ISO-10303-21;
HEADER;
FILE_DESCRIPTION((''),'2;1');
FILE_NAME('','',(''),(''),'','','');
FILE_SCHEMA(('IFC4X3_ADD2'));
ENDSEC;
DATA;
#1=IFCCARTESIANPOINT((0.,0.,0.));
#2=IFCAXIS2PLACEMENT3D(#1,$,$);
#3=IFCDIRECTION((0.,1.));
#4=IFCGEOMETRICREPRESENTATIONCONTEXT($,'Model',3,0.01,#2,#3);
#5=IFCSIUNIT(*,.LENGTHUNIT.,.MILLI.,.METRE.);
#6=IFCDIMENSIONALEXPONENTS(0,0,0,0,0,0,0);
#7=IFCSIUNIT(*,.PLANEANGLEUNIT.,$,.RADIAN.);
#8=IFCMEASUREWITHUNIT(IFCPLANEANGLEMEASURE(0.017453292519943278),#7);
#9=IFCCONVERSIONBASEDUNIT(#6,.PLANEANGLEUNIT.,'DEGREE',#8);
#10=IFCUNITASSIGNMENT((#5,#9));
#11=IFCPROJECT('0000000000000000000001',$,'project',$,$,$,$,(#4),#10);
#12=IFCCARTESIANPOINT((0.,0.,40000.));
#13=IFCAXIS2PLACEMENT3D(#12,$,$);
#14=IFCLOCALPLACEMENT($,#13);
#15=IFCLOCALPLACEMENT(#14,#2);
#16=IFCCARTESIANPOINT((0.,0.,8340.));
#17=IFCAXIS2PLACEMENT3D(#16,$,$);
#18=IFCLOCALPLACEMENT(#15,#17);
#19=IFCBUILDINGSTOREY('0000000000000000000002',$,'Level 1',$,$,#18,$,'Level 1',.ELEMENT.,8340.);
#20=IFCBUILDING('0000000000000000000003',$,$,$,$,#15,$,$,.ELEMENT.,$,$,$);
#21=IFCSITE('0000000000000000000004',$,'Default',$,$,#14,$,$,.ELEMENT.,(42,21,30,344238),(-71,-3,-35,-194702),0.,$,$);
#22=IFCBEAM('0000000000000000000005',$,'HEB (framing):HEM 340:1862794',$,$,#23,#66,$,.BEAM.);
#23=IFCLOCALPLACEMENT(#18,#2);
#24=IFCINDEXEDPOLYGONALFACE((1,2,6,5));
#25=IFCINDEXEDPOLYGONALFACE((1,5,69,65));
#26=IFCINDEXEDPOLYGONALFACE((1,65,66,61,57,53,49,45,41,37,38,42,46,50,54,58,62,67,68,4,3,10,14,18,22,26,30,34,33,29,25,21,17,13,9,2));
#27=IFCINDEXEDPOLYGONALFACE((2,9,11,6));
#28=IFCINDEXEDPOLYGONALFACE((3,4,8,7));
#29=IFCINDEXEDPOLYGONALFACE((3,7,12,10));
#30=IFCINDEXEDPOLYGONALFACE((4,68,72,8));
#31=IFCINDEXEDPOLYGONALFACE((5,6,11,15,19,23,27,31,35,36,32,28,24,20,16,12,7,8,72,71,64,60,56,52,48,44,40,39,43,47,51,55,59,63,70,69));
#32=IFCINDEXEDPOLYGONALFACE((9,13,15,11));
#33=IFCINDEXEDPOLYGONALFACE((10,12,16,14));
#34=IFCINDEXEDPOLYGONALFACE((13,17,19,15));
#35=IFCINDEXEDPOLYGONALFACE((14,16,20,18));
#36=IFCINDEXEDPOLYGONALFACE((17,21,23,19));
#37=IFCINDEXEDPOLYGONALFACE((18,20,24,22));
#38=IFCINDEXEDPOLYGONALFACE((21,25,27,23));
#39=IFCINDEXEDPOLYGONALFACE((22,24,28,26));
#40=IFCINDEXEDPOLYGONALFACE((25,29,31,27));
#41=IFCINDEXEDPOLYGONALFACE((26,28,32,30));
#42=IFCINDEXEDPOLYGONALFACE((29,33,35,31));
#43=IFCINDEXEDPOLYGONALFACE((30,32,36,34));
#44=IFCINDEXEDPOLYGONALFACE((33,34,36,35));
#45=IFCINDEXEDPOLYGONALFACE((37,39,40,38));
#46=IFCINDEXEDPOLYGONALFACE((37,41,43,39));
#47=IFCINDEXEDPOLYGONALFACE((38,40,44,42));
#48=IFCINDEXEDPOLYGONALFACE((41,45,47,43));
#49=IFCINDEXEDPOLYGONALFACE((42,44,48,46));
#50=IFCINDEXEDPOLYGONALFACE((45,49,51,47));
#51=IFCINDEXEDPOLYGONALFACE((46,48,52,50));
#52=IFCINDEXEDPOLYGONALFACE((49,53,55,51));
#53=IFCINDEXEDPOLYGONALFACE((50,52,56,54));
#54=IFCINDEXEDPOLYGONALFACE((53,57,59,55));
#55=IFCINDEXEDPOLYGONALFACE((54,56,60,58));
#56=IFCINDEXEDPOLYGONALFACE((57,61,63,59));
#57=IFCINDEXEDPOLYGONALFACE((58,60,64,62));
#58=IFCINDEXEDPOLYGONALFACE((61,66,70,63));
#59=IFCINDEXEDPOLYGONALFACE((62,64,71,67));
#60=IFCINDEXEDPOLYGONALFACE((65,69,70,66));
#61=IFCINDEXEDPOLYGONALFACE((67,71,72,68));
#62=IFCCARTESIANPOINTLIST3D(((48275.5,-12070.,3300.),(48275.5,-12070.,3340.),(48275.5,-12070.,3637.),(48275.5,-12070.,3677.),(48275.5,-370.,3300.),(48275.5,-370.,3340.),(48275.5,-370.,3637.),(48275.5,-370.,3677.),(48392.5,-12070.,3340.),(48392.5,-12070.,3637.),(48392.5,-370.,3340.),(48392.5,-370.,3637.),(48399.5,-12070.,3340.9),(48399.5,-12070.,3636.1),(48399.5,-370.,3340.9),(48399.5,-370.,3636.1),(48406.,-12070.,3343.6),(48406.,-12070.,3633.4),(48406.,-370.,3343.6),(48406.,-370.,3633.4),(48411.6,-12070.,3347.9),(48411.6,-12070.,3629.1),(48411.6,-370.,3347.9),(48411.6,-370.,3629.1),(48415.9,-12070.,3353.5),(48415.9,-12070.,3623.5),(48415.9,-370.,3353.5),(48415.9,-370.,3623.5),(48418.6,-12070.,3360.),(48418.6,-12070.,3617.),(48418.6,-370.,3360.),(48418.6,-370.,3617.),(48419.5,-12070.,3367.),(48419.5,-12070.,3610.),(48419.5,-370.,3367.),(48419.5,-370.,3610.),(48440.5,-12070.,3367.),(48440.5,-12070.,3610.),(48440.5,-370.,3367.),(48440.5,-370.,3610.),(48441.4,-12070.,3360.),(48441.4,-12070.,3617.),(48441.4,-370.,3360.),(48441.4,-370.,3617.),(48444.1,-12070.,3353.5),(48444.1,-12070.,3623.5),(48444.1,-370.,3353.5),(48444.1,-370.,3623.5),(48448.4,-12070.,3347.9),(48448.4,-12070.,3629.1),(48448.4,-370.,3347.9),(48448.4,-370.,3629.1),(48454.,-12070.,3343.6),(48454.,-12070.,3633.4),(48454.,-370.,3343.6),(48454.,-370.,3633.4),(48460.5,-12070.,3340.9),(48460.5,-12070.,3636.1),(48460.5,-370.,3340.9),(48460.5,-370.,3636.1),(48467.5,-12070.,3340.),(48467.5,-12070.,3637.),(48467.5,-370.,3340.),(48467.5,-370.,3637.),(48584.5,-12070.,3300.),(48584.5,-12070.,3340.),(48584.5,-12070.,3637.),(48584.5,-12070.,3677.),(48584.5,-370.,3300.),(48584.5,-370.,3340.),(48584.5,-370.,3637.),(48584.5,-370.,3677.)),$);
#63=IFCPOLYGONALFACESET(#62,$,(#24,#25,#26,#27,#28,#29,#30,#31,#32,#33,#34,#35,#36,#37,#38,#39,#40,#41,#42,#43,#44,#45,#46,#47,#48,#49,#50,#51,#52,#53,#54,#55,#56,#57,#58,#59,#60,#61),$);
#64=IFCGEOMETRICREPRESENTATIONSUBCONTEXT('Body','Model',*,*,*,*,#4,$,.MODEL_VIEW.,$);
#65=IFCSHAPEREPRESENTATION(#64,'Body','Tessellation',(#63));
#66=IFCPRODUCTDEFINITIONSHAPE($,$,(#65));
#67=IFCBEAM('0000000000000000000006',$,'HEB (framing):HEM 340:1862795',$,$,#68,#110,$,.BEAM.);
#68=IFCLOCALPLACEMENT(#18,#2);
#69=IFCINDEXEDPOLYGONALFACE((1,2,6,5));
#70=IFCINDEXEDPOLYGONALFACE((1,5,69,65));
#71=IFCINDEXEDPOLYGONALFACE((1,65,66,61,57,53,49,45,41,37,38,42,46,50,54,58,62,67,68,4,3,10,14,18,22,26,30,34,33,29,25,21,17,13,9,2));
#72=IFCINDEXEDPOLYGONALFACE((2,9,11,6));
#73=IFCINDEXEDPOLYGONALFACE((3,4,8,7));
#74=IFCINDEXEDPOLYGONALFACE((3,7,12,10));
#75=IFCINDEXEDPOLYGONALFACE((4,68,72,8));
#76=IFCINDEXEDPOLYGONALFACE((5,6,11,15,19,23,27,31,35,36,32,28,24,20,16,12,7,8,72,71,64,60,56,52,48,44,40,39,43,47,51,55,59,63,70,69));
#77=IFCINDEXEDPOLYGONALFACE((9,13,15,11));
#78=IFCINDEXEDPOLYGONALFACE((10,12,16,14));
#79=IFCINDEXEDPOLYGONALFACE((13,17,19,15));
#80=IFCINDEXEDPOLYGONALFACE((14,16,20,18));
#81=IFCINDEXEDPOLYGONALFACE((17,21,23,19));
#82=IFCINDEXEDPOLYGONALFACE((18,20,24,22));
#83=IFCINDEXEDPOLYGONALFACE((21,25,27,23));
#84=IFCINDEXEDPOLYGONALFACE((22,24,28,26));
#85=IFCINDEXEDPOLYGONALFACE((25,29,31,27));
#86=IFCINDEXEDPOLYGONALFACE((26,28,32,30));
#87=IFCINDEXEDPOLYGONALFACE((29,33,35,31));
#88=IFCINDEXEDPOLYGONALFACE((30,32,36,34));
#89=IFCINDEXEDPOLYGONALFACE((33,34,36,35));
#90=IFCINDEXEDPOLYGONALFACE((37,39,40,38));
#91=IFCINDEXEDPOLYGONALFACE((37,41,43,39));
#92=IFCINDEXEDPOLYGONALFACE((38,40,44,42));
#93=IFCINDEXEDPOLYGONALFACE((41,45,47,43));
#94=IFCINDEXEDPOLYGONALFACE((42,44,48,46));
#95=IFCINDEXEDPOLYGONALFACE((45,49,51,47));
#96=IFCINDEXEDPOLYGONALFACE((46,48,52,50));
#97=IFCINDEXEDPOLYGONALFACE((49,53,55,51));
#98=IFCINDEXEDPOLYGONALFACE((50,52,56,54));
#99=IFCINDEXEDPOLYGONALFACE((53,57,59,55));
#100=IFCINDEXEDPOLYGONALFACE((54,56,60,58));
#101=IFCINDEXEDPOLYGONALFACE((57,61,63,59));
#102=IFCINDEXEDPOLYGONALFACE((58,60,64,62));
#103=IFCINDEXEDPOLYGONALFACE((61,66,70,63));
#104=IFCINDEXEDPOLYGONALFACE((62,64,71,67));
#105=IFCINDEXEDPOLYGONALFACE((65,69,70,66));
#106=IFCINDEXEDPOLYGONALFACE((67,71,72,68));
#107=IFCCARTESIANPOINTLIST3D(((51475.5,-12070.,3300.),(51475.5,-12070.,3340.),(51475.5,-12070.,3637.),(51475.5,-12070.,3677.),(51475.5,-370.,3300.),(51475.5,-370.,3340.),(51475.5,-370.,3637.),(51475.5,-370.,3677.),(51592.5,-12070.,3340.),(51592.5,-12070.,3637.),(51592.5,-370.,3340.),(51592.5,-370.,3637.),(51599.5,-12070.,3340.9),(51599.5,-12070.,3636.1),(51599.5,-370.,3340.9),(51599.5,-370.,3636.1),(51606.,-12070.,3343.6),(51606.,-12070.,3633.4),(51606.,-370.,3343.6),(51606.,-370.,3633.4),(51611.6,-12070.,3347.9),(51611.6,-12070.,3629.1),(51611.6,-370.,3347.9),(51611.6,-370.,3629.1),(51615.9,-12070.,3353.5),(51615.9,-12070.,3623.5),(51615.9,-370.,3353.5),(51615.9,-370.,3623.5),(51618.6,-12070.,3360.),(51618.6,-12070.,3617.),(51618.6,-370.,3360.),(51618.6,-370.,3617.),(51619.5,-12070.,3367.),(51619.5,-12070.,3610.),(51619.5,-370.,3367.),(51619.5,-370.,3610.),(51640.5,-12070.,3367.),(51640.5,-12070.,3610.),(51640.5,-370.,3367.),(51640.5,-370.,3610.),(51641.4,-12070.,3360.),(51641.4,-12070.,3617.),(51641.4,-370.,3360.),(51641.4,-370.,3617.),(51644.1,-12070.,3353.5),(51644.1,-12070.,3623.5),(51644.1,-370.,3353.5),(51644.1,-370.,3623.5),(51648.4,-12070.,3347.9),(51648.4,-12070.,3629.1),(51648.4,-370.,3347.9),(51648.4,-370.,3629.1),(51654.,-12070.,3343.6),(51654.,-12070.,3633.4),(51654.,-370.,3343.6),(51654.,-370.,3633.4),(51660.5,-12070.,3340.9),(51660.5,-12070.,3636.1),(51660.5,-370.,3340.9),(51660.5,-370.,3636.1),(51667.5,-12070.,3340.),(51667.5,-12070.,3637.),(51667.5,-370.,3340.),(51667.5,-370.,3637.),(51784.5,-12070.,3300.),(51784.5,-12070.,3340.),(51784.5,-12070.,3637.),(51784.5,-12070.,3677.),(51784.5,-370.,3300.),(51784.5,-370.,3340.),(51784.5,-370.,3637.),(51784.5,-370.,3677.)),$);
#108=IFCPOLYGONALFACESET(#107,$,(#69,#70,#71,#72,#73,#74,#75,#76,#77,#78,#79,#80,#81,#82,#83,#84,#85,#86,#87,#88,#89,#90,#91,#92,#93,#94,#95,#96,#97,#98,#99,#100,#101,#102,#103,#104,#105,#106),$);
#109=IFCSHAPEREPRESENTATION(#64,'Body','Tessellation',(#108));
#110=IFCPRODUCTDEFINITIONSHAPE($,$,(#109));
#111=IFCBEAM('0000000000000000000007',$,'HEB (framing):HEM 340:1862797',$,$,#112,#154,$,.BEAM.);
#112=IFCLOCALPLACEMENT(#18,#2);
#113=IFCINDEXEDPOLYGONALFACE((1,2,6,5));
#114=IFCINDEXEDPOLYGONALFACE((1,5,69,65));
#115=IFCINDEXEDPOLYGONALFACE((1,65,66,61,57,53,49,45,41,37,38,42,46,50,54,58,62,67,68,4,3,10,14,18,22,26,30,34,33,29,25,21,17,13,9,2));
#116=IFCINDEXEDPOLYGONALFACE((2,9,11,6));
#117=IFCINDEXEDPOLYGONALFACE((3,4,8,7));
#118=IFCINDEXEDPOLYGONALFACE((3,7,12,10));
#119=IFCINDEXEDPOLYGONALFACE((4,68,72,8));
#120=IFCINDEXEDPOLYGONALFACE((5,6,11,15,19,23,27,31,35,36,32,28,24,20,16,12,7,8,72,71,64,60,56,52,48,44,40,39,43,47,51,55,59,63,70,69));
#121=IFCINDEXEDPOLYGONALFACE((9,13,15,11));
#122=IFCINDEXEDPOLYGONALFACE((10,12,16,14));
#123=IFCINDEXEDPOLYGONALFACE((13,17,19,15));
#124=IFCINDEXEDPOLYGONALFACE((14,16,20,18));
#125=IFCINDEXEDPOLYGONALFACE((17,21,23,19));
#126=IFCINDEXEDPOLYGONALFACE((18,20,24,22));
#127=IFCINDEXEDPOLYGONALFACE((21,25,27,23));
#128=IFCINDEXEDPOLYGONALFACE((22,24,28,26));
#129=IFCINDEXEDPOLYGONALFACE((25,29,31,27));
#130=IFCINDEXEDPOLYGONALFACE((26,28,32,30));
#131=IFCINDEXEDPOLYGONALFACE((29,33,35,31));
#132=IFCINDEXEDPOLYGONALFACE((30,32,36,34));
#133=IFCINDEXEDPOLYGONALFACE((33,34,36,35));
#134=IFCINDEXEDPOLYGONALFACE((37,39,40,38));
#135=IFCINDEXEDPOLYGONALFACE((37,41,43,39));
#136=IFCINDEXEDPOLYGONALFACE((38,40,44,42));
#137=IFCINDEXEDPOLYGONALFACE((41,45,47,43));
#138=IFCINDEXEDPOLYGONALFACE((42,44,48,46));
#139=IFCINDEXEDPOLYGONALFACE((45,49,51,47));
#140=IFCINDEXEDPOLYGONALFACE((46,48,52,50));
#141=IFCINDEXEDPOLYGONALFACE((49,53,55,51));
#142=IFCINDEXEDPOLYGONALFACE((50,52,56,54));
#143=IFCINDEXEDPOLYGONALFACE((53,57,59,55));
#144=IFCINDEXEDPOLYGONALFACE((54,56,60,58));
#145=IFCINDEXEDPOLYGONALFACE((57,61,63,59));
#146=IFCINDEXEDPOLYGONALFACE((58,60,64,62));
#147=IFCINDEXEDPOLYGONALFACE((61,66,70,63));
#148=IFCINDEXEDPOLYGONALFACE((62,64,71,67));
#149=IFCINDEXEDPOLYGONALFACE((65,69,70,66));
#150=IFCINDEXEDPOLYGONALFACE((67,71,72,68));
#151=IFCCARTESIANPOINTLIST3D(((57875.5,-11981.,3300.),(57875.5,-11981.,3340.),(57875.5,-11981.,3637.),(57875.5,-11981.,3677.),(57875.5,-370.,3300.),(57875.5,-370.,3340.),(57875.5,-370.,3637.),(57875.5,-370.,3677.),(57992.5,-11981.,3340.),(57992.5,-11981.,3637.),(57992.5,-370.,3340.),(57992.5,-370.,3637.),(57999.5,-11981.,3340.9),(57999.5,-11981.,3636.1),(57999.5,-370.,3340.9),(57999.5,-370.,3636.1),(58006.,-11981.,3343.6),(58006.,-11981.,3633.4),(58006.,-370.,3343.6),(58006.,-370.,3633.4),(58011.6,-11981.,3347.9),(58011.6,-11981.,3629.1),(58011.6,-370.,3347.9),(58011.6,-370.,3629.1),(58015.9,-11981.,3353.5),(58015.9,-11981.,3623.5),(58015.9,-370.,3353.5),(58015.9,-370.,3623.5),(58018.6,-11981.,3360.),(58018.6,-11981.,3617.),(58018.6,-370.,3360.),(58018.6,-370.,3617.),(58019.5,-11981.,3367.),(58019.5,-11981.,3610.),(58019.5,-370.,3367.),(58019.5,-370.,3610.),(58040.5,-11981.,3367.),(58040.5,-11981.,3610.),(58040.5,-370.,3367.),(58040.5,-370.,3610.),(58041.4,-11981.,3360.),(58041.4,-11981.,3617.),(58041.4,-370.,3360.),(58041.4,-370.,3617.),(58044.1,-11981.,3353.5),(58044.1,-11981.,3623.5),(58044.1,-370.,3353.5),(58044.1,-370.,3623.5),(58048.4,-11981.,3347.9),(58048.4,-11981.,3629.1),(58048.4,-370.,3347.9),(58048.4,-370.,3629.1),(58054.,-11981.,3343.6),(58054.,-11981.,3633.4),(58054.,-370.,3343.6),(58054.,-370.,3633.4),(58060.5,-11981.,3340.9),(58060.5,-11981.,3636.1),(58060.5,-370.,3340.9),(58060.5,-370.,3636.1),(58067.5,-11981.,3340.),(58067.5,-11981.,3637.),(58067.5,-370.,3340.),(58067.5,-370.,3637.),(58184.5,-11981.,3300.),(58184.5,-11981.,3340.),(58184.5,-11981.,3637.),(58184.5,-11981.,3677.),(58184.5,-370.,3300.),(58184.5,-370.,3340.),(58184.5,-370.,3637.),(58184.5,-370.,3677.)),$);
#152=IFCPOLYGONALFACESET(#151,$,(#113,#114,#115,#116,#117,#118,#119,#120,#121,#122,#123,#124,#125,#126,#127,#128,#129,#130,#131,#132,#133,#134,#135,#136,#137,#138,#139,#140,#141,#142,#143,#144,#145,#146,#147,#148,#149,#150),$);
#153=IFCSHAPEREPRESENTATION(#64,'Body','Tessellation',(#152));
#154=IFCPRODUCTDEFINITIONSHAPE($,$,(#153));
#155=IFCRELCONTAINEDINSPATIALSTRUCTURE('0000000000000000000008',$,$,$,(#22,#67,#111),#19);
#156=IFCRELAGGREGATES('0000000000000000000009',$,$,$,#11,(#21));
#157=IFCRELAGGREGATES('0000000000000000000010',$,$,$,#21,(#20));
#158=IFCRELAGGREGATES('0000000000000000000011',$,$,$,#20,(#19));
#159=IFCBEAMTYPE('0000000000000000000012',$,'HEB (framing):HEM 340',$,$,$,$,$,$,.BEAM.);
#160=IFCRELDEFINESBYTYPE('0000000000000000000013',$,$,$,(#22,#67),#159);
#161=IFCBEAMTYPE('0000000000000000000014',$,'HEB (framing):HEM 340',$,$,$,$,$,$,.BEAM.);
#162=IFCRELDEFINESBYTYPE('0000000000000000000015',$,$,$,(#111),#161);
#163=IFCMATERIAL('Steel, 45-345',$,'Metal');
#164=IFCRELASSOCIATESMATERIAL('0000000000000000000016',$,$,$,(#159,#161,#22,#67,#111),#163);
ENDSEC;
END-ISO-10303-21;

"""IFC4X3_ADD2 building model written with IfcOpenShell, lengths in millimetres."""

from ifc_helpers import new_model, entity, si_unit, converted_unit, direction, frame, frame_2d, origin, place, context, subcontext, project, spatial, polyline, circle_curve, parameter, trimmed, segment, composite_curve, outline, extrude, source, transform, mapped, material, material_profile, profile_set, profile_usage, type_object, type_shapes, element, save


model = new_model("IFC4X3_ADD2")

# Units and contexts
model_context = context("Model", 3, precision=0.01, world=origin(), true_north=direction((0.0, 1.0)))
body_context = subcontext(model_context, "Body", "Model", "MODEL_VIEW")
ifc_project = project(units=[si_unit("LENGTHUNIT", "METRE", prefix="MILLI"), converted_unit("PLANEANGLEUNIT", "DEGREE", entity("IfcPlaneAngleMeasure", 0.017453292519943278), si_unit("PLANEANGLEUNIT", "RADIAN"), dimensions=[0, 0, 0, 0, 0, 0, 0])], contexts=[model_context])

# Site, building, storey
site_placement = place(None, frame((0.0, 0.0, 40000.0)))
site = spatial("IfcSite", under=ifc_project, at=site_placement, Name="Default", CompositionType="ELEMENT", RefLatitude=(42, 21, 30, 344238), RefLongitude=(-71, -3, -35, -194702), RefElevation=0.0)
building_placement = place(site_placement, origin())
building = spatial("IfcBuilding", under=site, at=building_placement, CompositionType="ELEMENT")
storey_placement = place(building_placement, frame((0.0, 0.0, 8340.0)))
storey = spatial("IfcBuildingStorey", under=building, at=storey_placement, Name="Level 1", LongName="Level 1", CompositionType="ELEMENT", Elevation=8340.0)

# Shared definitions
ifc_material = material(Name="Steel, 45-345", Category="Metal")

# Beams
ifc_material_profile_1 = material_profile(ifc_material, outline(composite_curve([segment(polyline([(-154.5, -148.5), (-154.5, -188.5)]), True, "CONTINUOUS"), segment(polyline([(-154.5, -188.5), (154.5, -188.5)]), True, "CONTINUOUS"), segment(polyline([(154.5, -188.5), (154.5, -148.5)]), True, "CONTINUOUS"), segment(polyline([(154.5, -148.5), (37.5, -148.5)]), True, "CONTINUOUS"), segment(trimmed(circle_curve(frame_2d((37.5, -121.5), x_axis=(1.0, 0.0)), 27.0), [parameter(180.0)], [parameter(270.0)], True, "PARAMETER"), False, "CONTINUOUS"), segment(polyline([(10.5, -121.5), (10.5, 121.5)]), True, "CONTINUOUS"), segment(trimmed(circle_curve(frame_2d((37.5, 121.5), x_axis=(1.0, 0.0)), 27.0), [parameter(90.0)], [parameter(180.0)], True, "PARAMETER"), False, "CONTINUOUS"), segment(polyline([(37.5, 148.5), (154.5, 148.5)]), True, "CONTINUOUS"), segment(polyline([(154.5, 148.5), (154.5, 188.5)]), True, "CONTINUOUS"), segment(polyline([(154.5, 188.5), (-154.5, 188.5)]), True, "CONTINUOUS"), segment(polyline([(-154.5, 188.5), (-154.5, 148.5)]), True, "CONTINUOUS"), segment(polyline([(-154.5, 148.5), (-37.5, 148.5)]), True, "CONTINUOUS"), segment(trimmed(circle_curve(frame_2d((-37.5, 121.5), x_axis=(1.0, 0.0)), 27.0), [parameter(360.0)], [parameter(90.0)], True, "PARAMETER"), False, "CONTINUOUS"), segment(polyline([(-10.5, 121.5), (-10.5, -121.5)]), True, "CONTINUOUS"), segment(trimmed(circle_curve(frame_2d((-37.5, -121.5), x_axis=(1.0, 0.0)), 27.0), [parameter(270.0)], [parameter(0.0)], True, "PARAMETER"), False, "CONTINUOUS"), segment(polyline([(-37.5, -148.5), (-154.5, -148.5)]), True, "CONTINUOUS")], self_intersect=False)), Name="HEM 340")
ifc_profile_set_1 = profile_set([ifc_material_profile_1], Name="HEM 340")
ifc_profile_usage_1 = profile_usage(ifc_profile_set_1, cardinal=8)
beam_type_1 = type_object("IfcBeamType", Name="HEB (framing):HEM 340", PredefinedType="BEAM", material=ifc_profile_set_1)
shared_shape_1 = source(origin(), body_context, "Body", "SweptSolid", [
    extrude(outline(composite_curve([segment(polyline([(-154.5, -148.5), (-154.5, -188.5)]), True, "CONTINUOUS"), segment(polyline([(-154.5, -188.5), (154.5, -188.5)]), True, "CONTINUOUS"), segment(polyline([(154.5, -188.5), (154.5, -148.5)]), True, "CONTINUOUS"), segment(polyline([(154.5, -148.5), (37.5, -148.5)]), True, "CONTINUOUS"), segment(trimmed(circle_curve(frame_2d((37.5, -121.5), x_axis=(1.0, 0.0)), 27.0), [parameter(180.0)], [parameter(270.0)], True, "PARAMETER"), False, "CONTINUOUS"), segment(polyline([(10.5, -121.5), (10.5, 121.5)]), True, "CONTINUOUS"), segment(trimmed(circle_curve(frame_2d((37.5, 121.5), x_axis=(1.0, 0.0)), 27.0), [parameter(90.0)], [parameter(180.0)], True, "PARAMETER"), False, "CONTINUOUS"), segment(polyline([(37.5, 148.5), (154.5, 148.5)]), True, "CONTINUOUS"), segment(polyline([(154.5, 148.5), (154.5, 188.5)]), True, "CONTINUOUS"), segment(polyline([(154.5, 188.5), (-154.5, 188.5)]), True, "CONTINUOUS"), segment(polyline([(-154.5, 188.5), (-154.5, 148.5)]), True, "CONTINUOUS"), segment(polyline([(-154.5, 148.5), (-37.5, 148.5)]), True, "CONTINUOUS"), segment(trimmed(circle_curve(frame_2d((-37.5, 121.5), x_axis=(1.0, 0.0)), 27.0), [parameter(360.0)], [parameter(90.0)], True, "PARAMETER"), False, "CONTINUOUS"), segment(polyline([(-10.5, 121.5), (-10.5, -121.5)]), True, "CONTINUOUS"), segment(trimmed(circle_curve(frame_2d((-37.5, -121.5), x_axis=(1.0, 0.0)), 27.0), [parameter(270.0)], [parameter(0.0)], True, "PARAMETER"), False, "CONTINUOUS"), segment(polyline([(-37.5, -148.5), (-154.5, -148.5)]), True, "CONTINUOUS")], self_intersect=False)), frame((-5850.0, 0.0, 0.0), z_axis=(-1.0, 0.0, 0.0), x_axis=(0.0, -1.0, 0.0)), (0.0, 0.0, -1.0), 11700.0),
])
type_shapes(beam_type_1, [shared_shape_1])
for number, where, z_axis, x_axis, name in (
    (1, (48430.0, -6220.0, 3488.5), (0.0, 0.0, 1.0), (0.0, -1.0, 0.0), "HEB (framing):HEM 340:1862794"),
    (2, (51630.0, -6220.0, 3488.5), (0.0, 0.0, 1.0), (0.0, -1.0, 0.0), "HEB (framing):HEM 340:1862795"),
):
    element("IfcBeam", number, at=place(storey_placement, frame(where, z_axis=z_axis, x_axis=x_axis)), inside=storey, type_object=beam_type_1, material=ifc_profile_usage_1, Name=name, PredefinedType="BEAM", context=body_context, shape_type="MappedRepresentation", body=[
        mapped(shared_shape_1, transform((0.0, 0.0, 0.0), scale=1.0)),
    ])
beam_type_2 = type_object("IfcBeamType", Name="HEB (framing):HEM 340", PredefinedType="BEAM", material=ifc_profile_set_1)
shared_shape_2 = source(origin(), body_context, "Body", "SweptSolid", [
    extrude(outline(composite_curve([segment(polyline([(-154.5, -148.5), (-154.5, -188.5)]), True, "CONTINUOUS"), segment(polyline([(-154.5, -188.5), (154.5, -188.5)]), True, "CONTINUOUS"), segment(polyline([(154.5, -188.5), (154.5, -148.5)]), True, "CONTINUOUS"), segment(polyline([(154.5, -148.5), (37.5, -148.5)]), True, "CONTINUOUS"), segment(trimmed(circle_curve(frame_2d((37.5, -121.5), x_axis=(1.0, 0.0)), 27.0), [parameter(180.0)], [parameter(270.0)], True, "PARAMETER"), False, "CONTINUOUS"), segment(polyline([(10.5, -121.5), (10.5, 121.5)]), True, "CONTINUOUS"), segment(trimmed(circle_curve(frame_2d((37.5, 121.5), x_axis=(1.0, 0.0)), 27.0), [parameter(90.0)], [parameter(180.0)], True, "PARAMETER"), False, "CONTINUOUS"), segment(polyline([(37.5, 148.5), (154.5, 148.5)]), True, "CONTINUOUS"), segment(polyline([(154.5, 148.5), (154.5, 188.5)]), True, "CONTINUOUS"), segment(polyline([(154.5, 188.5), (-154.5, 188.5)]), True, "CONTINUOUS"), segment(polyline([(-154.5, 188.5), (-154.5, 148.5)]), True, "CONTINUOUS"), segment(polyline([(-154.5, 148.5), (-37.5, 148.5)]), True, "CONTINUOUS"), segment(trimmed(circle_curve(frame_2d((-37.5, 121.5), x_axis=(1.0, 0.0)), 27.0), [parameter(360.0)], [parameter(90.0)], True, "PARAMETER"), False, "CONTINUOUS"), segment(polyline([(-10.5, 121.5), (-10.5, -121.5)]), True, "CONTINUOUS"), segment(trimmed(circle_curve(frame_2d((-37.5, -121.5), x_axis=(1.0, 0.0)), 27.0), [parameter(270.0)], [parameter(0.0)], True, "PARAMETER"), False, "CONTINUOUS"), segment(polyline([(-37.5, -148.5), (-154.5, -148.5)]), True, "CONTINUOUS")], self_intersect=False)), frame((-5850.0, 0.0, 0.0), z_axis=(-1.0, 0.0, 0.0), x_axis=(0.0, -1.0, 0.0)), (0.0, 0.0, -1.0), 11611.0),
])
type_shapes(beam_type_2, [shared_shape_2])
beam_1_placement = place(storey_placement, frame((58030.0, -6220.0, 3488.5), z_axis=(0.0, 0.0, 1.0), x_axis=(0.0, -1.0, 0.0)))
element("IfcBeam", 3, at=beam_1_placement, inside=storey, type_object=beam_type_2, material=ifc_profile_usage_1, Name="HEB (framing):HEM 340:1862797", PredefinedType="BEAM", context=body_context, shape_type="MappedRepresentation", body=[
    mapped(shared_shape_2, transform((0.0, 0.0, 0.0), scale=1.0)),
])

save(model, "model.ifc")
